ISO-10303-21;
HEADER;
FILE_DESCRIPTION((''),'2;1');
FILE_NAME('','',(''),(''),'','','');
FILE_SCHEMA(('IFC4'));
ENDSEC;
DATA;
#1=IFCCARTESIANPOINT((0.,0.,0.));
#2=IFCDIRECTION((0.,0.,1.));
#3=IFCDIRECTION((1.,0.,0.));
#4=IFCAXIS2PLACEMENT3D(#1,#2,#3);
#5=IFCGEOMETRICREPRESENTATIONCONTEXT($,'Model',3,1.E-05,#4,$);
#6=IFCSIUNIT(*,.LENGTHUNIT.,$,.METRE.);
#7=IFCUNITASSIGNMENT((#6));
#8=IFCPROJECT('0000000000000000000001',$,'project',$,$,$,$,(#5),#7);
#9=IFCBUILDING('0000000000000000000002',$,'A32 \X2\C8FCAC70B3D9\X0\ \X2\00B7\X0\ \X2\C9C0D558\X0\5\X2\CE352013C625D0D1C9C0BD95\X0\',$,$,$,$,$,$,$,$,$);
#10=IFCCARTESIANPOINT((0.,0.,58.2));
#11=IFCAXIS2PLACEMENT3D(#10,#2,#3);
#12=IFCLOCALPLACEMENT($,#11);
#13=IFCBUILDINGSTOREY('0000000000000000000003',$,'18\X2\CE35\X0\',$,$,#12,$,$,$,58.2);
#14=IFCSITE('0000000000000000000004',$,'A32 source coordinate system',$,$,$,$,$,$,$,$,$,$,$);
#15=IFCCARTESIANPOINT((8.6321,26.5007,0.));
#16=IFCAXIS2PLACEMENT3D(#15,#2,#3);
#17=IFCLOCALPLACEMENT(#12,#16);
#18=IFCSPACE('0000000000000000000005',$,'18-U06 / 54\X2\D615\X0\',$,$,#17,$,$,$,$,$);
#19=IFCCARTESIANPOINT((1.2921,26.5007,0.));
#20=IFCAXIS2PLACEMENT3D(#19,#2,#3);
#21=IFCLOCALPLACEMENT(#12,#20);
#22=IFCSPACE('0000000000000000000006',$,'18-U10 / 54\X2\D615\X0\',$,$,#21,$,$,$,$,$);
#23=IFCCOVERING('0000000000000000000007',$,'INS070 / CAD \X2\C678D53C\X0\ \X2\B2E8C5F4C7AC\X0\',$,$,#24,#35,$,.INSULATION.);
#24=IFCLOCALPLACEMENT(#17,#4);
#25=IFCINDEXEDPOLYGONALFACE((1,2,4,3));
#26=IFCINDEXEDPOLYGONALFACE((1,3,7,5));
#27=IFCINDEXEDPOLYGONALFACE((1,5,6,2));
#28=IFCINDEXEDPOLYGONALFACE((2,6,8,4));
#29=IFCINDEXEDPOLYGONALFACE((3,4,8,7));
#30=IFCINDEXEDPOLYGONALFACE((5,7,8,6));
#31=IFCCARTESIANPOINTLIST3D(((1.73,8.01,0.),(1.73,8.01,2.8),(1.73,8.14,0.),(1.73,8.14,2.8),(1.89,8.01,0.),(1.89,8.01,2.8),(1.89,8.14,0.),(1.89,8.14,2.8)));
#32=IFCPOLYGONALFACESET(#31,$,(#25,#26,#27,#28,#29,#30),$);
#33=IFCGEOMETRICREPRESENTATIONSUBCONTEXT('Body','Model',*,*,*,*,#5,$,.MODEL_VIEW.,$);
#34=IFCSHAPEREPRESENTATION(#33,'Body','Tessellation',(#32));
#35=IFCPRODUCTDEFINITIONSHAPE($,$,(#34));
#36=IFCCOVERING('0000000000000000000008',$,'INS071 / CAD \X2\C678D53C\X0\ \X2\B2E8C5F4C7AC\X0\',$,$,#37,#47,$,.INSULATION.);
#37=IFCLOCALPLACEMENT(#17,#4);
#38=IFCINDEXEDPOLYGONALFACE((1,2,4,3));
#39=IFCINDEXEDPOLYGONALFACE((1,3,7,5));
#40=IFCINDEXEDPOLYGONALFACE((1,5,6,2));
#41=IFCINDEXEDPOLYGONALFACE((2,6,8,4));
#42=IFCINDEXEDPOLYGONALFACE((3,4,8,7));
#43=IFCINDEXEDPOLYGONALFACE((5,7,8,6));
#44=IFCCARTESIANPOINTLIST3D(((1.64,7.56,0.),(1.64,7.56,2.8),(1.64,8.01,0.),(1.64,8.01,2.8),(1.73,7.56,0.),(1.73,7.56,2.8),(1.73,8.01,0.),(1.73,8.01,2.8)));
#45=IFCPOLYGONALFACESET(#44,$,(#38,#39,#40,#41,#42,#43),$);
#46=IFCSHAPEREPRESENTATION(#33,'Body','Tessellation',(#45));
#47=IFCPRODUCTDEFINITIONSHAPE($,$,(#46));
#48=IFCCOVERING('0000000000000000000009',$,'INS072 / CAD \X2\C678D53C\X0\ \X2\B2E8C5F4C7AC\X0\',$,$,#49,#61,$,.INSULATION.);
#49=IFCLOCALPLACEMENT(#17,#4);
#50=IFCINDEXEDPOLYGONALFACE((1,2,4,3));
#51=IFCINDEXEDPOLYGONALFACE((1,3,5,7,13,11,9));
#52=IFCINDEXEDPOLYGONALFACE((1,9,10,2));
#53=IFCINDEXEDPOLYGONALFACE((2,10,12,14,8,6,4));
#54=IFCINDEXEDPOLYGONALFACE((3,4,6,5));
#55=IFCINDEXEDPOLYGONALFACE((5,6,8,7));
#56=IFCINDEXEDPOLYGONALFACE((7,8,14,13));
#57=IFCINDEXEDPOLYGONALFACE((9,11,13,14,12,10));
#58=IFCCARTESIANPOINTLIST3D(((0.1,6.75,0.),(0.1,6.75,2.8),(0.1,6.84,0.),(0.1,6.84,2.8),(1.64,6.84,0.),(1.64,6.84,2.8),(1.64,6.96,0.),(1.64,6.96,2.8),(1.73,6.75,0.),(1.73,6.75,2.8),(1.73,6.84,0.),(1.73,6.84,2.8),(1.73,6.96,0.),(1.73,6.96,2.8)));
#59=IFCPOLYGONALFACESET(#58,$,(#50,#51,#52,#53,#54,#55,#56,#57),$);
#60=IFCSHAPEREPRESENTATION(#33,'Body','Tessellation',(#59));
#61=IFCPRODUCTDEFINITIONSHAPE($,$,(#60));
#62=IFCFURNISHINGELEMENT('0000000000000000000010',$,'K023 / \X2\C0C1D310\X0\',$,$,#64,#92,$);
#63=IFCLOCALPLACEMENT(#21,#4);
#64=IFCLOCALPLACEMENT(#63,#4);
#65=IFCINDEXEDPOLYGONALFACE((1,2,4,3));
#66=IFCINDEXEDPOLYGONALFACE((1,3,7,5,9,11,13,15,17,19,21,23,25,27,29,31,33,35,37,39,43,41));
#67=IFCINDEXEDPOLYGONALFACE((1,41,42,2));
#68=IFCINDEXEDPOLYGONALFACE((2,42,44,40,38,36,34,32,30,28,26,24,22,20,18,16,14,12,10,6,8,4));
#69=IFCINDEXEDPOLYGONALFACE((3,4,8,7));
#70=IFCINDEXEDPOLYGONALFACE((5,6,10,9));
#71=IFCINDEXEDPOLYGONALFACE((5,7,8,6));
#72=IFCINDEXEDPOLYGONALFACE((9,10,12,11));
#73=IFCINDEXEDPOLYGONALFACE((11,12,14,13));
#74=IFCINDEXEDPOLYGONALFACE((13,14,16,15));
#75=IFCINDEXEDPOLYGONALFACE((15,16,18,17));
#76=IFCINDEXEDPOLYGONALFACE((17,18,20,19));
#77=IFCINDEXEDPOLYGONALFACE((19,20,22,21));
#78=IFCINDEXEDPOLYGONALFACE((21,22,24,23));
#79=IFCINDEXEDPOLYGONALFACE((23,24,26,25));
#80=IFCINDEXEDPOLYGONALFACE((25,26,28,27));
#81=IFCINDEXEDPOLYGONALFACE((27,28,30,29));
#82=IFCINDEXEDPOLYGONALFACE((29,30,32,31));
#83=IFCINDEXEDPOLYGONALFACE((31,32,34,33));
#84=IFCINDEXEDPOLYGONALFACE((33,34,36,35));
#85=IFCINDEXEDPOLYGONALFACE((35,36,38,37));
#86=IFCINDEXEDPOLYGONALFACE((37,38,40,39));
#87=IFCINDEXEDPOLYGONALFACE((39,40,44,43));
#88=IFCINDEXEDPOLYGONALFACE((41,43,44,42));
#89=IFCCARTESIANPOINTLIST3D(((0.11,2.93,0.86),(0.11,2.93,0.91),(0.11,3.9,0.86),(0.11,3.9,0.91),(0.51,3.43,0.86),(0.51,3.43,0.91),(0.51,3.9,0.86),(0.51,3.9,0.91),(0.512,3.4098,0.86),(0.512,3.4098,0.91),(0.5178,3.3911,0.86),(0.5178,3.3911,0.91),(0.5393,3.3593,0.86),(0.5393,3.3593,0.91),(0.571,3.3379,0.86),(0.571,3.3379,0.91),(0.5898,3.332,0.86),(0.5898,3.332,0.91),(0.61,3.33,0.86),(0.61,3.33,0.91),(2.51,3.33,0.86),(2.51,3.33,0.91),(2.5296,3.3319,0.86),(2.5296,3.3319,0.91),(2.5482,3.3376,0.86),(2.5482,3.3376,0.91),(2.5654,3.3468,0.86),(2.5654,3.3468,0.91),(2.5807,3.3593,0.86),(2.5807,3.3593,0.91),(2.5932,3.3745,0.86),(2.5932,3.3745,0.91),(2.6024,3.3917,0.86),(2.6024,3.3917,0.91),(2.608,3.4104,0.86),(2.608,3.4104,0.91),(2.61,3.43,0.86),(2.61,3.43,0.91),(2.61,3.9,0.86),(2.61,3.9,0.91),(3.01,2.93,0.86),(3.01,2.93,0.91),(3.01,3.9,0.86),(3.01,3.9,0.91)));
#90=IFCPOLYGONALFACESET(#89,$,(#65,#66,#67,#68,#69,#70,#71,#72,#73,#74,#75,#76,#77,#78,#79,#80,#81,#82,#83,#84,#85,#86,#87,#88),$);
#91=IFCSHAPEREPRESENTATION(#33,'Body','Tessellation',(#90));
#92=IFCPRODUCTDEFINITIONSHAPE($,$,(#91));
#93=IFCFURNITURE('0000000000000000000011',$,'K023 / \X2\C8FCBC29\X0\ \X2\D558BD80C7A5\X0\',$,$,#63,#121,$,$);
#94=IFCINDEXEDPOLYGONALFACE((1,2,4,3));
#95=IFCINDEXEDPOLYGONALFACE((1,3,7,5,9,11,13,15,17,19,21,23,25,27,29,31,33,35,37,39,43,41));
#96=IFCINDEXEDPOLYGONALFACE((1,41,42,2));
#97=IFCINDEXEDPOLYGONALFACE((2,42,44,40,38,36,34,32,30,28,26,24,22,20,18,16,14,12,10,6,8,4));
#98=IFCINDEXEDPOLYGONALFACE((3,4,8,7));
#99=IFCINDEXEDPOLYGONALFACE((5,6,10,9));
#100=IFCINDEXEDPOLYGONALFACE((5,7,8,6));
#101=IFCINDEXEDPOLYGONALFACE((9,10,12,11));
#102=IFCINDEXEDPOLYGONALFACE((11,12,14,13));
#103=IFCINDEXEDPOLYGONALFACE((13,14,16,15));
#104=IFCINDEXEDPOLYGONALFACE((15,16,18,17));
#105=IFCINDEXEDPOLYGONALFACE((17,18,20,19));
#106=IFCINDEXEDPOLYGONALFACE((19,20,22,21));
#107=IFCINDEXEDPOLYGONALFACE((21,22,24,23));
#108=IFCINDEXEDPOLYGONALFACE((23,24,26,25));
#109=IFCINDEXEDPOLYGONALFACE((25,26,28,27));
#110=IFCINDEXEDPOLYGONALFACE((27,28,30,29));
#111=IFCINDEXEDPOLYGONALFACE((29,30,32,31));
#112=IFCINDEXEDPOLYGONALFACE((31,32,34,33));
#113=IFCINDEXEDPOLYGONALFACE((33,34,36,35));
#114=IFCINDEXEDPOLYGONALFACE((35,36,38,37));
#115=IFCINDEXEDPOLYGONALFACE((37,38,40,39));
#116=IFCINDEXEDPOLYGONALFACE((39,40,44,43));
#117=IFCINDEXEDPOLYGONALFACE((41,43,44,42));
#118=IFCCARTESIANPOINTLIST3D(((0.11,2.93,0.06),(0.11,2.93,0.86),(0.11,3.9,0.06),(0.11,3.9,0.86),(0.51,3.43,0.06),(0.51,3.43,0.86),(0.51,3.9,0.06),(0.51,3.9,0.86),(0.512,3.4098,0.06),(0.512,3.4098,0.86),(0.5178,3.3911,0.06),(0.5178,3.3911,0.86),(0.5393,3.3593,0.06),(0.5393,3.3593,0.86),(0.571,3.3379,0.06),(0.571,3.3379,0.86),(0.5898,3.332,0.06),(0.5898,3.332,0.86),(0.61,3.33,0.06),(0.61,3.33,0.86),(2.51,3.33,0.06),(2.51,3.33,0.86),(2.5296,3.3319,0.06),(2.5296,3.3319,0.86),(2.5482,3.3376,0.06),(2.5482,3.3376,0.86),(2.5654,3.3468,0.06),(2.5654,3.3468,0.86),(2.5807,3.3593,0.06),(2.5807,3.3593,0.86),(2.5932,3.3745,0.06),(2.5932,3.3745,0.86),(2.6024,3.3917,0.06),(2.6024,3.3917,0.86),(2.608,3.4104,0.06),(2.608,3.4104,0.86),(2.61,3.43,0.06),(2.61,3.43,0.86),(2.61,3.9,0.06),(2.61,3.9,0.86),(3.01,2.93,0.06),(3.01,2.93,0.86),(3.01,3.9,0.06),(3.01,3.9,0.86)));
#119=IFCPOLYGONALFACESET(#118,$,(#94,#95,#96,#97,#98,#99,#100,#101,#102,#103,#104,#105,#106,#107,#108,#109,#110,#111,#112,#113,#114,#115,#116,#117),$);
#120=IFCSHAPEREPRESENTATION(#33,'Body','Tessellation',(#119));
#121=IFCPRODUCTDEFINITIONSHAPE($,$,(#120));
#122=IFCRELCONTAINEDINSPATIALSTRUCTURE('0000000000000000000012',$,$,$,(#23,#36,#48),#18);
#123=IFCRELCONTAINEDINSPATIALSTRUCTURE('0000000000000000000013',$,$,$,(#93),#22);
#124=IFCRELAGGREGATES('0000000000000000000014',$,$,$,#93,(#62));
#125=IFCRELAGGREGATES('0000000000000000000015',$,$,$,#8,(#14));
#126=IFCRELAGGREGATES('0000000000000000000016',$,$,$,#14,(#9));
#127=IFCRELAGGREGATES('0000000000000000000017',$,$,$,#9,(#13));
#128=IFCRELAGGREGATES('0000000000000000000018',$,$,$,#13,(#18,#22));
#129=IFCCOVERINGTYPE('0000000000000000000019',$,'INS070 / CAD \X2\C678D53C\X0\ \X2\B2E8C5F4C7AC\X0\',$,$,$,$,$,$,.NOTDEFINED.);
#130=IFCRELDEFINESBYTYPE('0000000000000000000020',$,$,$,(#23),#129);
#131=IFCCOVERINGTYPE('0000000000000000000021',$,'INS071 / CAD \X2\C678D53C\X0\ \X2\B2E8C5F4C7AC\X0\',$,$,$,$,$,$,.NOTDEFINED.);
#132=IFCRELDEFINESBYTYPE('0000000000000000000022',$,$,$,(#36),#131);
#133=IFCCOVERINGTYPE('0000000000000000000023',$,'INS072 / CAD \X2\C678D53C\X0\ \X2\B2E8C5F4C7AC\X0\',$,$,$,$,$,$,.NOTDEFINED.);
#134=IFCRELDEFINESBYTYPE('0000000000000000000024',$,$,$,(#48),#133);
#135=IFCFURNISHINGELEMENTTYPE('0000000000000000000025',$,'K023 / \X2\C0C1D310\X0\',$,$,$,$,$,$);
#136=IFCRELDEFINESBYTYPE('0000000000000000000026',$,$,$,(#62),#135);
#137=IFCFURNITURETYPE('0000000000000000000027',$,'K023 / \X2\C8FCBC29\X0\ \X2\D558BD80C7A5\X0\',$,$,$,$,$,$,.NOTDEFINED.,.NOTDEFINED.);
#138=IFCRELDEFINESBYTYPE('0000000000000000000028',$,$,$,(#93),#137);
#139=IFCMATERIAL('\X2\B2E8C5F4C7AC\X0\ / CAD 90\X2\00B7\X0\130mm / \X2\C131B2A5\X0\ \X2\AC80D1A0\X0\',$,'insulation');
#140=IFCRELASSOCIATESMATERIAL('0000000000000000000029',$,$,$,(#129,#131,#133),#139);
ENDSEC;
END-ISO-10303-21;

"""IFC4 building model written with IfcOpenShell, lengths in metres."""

from ifc_helpers import new_model, si_unit, frame, origin, origin_with_axes, place, context, subcontext, project, spatial, polyline, outline, extrude, source, transform, mapped, material, type_object, type_shapes, element, aggregate, save


model = new_model("IFC4")

# Units and contexts
model_context = context("Model", 3, precision=1e-05, world=origin_with_axes())
body_context = subcontext(model_context, "Body", "Model", "MODEL_VIEW")
ifc_project = project(units=[si_unit("LENGTHUNIT", "METRE")], contexts=[model_context])

# Site, building, storey, space
storey_placement = place(None, frame((0.0, 0.0, 58.2), z_axis=(0.0, 0.0, 1.0), x_axis=(1.0, 0.0, 0.0)))
space_1_placement = place(storey_placement, frame((8.6321, 26.5007, 0.0), z_axis=(0.0, 0.0, 1.0), x_axis=(1.0, 0.0, 0.0)))
site = spatial("IfcSite", under=ifc_project, Name="A32 source coordinate system")
building = spatial("IfcBuilding", under=site, Name="A32 주거동 · 지하5층–옥탑지붕")
storey = spatial("IfcBuildingStorey", under=building, at=storey_placement, Name="18층", Elevation=58.2)
space_1 = spatial("IfcSpace", under=storey, at=space_1_placement, Name="18-U06 / 54형")

# Coverings
ifc_material = material(Name="단열재 / CAD 90·130mm / 성능 검토", Category="insulation")
covering_type_1 = type_object("IfcCoveringType", Name="INS070 / CAD 외피 단열재", PredefinedType="NOTDEFINED", material=ifc_material)
shared_shape_1 = source(origin(), body_context, "Body", "SweptSolid", [
    extrude(outline(polyline([(1.73, 8.14), (1.89, 8.14), (1.89, 8.01), (1.73, 8.01), (1.73, 8.14)])), origin(), (0.0, 0.0, 1.0), 2.8),
])
type_shapes(covering_type_1, [shared_shape_1])
covering_1_placement = place(space_1_placement, origin_with_axes())
element("IfcCovering", 1, at=covering_1_placement, inside=space_1, type_object=covering_type_1, Name="INS070 / CAD 외피 단열재", PredefinedType="INSULATION", context=body_context, shape_type="MappedRepresentation", body=[
    mapped(shared_shape_1, transform((0.0, 0.0, 0.0), scale=1.0)),
])
covering_type_2 = type_object("IfcCoveringType", Name="INS071 / CAD 외피 단열재", PredefinedType="NOTDEFINED", material=ifc_material)
shared_shape_2 = source(origin(), body_context, "Body", "SweptSolid", [
    extrude(outline(polyline([(1.73, 7.56), (1.64, 7.56), (1.64, 8.01), (1.73, 8.01), (1.73, 7.56)])), origin(), (0.0, 0.0, 1.0), 2.8),
])
type_shapes(covering_type_2, [shared_shape_2])
covering_2_placement = place(space_1_placement, origin_with_axes())
element("IfcCovering", 2, at=covering_2_placement, inside=space_1, type_object=covering_type_2, Name="INS071 / CAD 외피 단열재", PredefinedType="INSULATION", context=body_context, shape_type="MappedRepresentation", body=[
    mapped(shared_shape_2, transform((0.0, 0.0, 0.0), scale=1.0)),
])
covering_type_3 = type_object("IfcCoveringType", Name="INS072 / CAD 외피 단열재", PredefinedType="NOTDEFINED", material=ifc_material)
shared_shape_3 = source(origin(), body_context, "Body", "SweptSolid", [
    extrude(outline(polyline([(1.64, 6.84), (1.64, 6.96), (1.73, 6.96), (1.73, 6.84), (1.73, 6.75), (0.1, 6.75), (0.1, 6.84), (1.64, 6.84)])), origin(), (0.0, 0.0, 1.0), 2.8),
])
type_shapes(covering_type_3, [shared_shape_3])
covering_3_placement = place(space_1_placement, origin_with_axes())
element("IfcCovering", 3, at=covering_3_placement, inside=space_1, type_object=covering_type_3, Name="INS072 / CAD 외피 단열재", PredefinedType="INSULATION", context=body_context, shape_type="MappedRepresentation", body=[
    mapped(shared_shape_3, transform((0.0, 0.0, 0.0), scale=1.0)),
])

# Shared definitions
space_2_placement = place(storey_placement, frame((1.2921, 26.5007, 0.0), z_axis=(0.0, 0.0, 1.0), x_axis=(1.0, 0.0, 0.0)))

# Furnishing element
furnishing_element_type_1 = type_object("IfcFurnishingElementType", Name="K023 / 상판")
shared_shape_4 = source(origin(), body_context, "Body", "SweptSolid", [
    extrude(outline(polyline([(0.51, 3.43), (0.512, 3.4098), (0.5178, 3.3911), (0.5393, 3.3593), (0.571, 3.3379), (0.5898, 3.332), (0.61, 3.33), (2.51, 3.33), (2.5296, 3.3319), (2.5482, 3.3376), (2.5654, 3.3468), (2.5807, 3.3593), (2.5932, 3.3745), (2.6024, 3.3917), (2.608, 3.4104), (2.61, 3.43), (2.61, 3.9), (3.01, 3.9), (3.01, 2.93), (0.11, 2.93), (0.11, 3.9), (0.51, 3.9), (0.51, 3.43)])), frame((0.0, 0.0, 0.86)), (0.0, 0.0, 1.0), 0.05),
])
type_shapes(furnishing_element_type_1, [shared_shape_4])
furniture_1_placement = place(space_2_placement, origin_with_axes())
furnishing_1_placement = place(furniture_1_placement, origin_with_axes())
furnishing_1 = element("IfcFurnishingElement", 4, at=furnishing_1_placement, type_object=furnishing_element_type_1, Name="K023 / 상판", context=body_context, shape_type="MappedRepresentation", body=[
    mapped(shared_shape_4, transform((0.0, 0.0, 0.0), scale=1.0)),
])

# Shared definitions
space_2 = spatial("IfcSpace", under=storey, at=space_2_placement, Name="18-U10 / 54형")

# Furniture
furniture_type_1 = type_object("IfcFurnitureType", Name="K023 / 주방 하부장", AssemblyPlace="NOTDEFINED", PredefinedType="NOTDEFINED")
shared_shape_5 = source(origin(), body_context, "Body", "SweptSolid", [
    extrude(outline(polyline([(0.51, 3.9), (0.51, 3.43), (0.512, 3.4098), (0.5178, 3.3911), (0.5393, 3.3593), (0.571, 3.3379), (0.5898, 3.332), (0.61, 3.33), (2.51, 3.33), (2.5296, 3.3319), (2.5482, 3.3376), (2.5654, 3.3468), (2.5807, 3.3593), (2.5932, 3.3745), (2.6024, 3.3917), (2.608, 3.4104), (2.61, 3.43), (2.61, 3.9), (3.01, 3.9), (3.01, 2.93), (0.11, 2.93), (0.11, 3.9), (0.51, 3.9)])), frame((0.0, 0.0, 0.06)), (0.0, 0.0, 1.0), 0.8),
])
type_shapes(furniture_type_1, [shared_shape_5])
furniture_1 = element("IfcFurniture", 5, at=furniture_1_placement, inside=space_2, type_object=furniture_type_1, Name="K023 / 주방 하부장", context=body_context, shape_type="MappedRepresentation", body=[
    mapped(shared_shape_5, transform((0.0, 0.0, 0.0), scale=1.0)),
])
aggregate(furniture_1, [furnishing_1])

save(model, "model.ifc")
